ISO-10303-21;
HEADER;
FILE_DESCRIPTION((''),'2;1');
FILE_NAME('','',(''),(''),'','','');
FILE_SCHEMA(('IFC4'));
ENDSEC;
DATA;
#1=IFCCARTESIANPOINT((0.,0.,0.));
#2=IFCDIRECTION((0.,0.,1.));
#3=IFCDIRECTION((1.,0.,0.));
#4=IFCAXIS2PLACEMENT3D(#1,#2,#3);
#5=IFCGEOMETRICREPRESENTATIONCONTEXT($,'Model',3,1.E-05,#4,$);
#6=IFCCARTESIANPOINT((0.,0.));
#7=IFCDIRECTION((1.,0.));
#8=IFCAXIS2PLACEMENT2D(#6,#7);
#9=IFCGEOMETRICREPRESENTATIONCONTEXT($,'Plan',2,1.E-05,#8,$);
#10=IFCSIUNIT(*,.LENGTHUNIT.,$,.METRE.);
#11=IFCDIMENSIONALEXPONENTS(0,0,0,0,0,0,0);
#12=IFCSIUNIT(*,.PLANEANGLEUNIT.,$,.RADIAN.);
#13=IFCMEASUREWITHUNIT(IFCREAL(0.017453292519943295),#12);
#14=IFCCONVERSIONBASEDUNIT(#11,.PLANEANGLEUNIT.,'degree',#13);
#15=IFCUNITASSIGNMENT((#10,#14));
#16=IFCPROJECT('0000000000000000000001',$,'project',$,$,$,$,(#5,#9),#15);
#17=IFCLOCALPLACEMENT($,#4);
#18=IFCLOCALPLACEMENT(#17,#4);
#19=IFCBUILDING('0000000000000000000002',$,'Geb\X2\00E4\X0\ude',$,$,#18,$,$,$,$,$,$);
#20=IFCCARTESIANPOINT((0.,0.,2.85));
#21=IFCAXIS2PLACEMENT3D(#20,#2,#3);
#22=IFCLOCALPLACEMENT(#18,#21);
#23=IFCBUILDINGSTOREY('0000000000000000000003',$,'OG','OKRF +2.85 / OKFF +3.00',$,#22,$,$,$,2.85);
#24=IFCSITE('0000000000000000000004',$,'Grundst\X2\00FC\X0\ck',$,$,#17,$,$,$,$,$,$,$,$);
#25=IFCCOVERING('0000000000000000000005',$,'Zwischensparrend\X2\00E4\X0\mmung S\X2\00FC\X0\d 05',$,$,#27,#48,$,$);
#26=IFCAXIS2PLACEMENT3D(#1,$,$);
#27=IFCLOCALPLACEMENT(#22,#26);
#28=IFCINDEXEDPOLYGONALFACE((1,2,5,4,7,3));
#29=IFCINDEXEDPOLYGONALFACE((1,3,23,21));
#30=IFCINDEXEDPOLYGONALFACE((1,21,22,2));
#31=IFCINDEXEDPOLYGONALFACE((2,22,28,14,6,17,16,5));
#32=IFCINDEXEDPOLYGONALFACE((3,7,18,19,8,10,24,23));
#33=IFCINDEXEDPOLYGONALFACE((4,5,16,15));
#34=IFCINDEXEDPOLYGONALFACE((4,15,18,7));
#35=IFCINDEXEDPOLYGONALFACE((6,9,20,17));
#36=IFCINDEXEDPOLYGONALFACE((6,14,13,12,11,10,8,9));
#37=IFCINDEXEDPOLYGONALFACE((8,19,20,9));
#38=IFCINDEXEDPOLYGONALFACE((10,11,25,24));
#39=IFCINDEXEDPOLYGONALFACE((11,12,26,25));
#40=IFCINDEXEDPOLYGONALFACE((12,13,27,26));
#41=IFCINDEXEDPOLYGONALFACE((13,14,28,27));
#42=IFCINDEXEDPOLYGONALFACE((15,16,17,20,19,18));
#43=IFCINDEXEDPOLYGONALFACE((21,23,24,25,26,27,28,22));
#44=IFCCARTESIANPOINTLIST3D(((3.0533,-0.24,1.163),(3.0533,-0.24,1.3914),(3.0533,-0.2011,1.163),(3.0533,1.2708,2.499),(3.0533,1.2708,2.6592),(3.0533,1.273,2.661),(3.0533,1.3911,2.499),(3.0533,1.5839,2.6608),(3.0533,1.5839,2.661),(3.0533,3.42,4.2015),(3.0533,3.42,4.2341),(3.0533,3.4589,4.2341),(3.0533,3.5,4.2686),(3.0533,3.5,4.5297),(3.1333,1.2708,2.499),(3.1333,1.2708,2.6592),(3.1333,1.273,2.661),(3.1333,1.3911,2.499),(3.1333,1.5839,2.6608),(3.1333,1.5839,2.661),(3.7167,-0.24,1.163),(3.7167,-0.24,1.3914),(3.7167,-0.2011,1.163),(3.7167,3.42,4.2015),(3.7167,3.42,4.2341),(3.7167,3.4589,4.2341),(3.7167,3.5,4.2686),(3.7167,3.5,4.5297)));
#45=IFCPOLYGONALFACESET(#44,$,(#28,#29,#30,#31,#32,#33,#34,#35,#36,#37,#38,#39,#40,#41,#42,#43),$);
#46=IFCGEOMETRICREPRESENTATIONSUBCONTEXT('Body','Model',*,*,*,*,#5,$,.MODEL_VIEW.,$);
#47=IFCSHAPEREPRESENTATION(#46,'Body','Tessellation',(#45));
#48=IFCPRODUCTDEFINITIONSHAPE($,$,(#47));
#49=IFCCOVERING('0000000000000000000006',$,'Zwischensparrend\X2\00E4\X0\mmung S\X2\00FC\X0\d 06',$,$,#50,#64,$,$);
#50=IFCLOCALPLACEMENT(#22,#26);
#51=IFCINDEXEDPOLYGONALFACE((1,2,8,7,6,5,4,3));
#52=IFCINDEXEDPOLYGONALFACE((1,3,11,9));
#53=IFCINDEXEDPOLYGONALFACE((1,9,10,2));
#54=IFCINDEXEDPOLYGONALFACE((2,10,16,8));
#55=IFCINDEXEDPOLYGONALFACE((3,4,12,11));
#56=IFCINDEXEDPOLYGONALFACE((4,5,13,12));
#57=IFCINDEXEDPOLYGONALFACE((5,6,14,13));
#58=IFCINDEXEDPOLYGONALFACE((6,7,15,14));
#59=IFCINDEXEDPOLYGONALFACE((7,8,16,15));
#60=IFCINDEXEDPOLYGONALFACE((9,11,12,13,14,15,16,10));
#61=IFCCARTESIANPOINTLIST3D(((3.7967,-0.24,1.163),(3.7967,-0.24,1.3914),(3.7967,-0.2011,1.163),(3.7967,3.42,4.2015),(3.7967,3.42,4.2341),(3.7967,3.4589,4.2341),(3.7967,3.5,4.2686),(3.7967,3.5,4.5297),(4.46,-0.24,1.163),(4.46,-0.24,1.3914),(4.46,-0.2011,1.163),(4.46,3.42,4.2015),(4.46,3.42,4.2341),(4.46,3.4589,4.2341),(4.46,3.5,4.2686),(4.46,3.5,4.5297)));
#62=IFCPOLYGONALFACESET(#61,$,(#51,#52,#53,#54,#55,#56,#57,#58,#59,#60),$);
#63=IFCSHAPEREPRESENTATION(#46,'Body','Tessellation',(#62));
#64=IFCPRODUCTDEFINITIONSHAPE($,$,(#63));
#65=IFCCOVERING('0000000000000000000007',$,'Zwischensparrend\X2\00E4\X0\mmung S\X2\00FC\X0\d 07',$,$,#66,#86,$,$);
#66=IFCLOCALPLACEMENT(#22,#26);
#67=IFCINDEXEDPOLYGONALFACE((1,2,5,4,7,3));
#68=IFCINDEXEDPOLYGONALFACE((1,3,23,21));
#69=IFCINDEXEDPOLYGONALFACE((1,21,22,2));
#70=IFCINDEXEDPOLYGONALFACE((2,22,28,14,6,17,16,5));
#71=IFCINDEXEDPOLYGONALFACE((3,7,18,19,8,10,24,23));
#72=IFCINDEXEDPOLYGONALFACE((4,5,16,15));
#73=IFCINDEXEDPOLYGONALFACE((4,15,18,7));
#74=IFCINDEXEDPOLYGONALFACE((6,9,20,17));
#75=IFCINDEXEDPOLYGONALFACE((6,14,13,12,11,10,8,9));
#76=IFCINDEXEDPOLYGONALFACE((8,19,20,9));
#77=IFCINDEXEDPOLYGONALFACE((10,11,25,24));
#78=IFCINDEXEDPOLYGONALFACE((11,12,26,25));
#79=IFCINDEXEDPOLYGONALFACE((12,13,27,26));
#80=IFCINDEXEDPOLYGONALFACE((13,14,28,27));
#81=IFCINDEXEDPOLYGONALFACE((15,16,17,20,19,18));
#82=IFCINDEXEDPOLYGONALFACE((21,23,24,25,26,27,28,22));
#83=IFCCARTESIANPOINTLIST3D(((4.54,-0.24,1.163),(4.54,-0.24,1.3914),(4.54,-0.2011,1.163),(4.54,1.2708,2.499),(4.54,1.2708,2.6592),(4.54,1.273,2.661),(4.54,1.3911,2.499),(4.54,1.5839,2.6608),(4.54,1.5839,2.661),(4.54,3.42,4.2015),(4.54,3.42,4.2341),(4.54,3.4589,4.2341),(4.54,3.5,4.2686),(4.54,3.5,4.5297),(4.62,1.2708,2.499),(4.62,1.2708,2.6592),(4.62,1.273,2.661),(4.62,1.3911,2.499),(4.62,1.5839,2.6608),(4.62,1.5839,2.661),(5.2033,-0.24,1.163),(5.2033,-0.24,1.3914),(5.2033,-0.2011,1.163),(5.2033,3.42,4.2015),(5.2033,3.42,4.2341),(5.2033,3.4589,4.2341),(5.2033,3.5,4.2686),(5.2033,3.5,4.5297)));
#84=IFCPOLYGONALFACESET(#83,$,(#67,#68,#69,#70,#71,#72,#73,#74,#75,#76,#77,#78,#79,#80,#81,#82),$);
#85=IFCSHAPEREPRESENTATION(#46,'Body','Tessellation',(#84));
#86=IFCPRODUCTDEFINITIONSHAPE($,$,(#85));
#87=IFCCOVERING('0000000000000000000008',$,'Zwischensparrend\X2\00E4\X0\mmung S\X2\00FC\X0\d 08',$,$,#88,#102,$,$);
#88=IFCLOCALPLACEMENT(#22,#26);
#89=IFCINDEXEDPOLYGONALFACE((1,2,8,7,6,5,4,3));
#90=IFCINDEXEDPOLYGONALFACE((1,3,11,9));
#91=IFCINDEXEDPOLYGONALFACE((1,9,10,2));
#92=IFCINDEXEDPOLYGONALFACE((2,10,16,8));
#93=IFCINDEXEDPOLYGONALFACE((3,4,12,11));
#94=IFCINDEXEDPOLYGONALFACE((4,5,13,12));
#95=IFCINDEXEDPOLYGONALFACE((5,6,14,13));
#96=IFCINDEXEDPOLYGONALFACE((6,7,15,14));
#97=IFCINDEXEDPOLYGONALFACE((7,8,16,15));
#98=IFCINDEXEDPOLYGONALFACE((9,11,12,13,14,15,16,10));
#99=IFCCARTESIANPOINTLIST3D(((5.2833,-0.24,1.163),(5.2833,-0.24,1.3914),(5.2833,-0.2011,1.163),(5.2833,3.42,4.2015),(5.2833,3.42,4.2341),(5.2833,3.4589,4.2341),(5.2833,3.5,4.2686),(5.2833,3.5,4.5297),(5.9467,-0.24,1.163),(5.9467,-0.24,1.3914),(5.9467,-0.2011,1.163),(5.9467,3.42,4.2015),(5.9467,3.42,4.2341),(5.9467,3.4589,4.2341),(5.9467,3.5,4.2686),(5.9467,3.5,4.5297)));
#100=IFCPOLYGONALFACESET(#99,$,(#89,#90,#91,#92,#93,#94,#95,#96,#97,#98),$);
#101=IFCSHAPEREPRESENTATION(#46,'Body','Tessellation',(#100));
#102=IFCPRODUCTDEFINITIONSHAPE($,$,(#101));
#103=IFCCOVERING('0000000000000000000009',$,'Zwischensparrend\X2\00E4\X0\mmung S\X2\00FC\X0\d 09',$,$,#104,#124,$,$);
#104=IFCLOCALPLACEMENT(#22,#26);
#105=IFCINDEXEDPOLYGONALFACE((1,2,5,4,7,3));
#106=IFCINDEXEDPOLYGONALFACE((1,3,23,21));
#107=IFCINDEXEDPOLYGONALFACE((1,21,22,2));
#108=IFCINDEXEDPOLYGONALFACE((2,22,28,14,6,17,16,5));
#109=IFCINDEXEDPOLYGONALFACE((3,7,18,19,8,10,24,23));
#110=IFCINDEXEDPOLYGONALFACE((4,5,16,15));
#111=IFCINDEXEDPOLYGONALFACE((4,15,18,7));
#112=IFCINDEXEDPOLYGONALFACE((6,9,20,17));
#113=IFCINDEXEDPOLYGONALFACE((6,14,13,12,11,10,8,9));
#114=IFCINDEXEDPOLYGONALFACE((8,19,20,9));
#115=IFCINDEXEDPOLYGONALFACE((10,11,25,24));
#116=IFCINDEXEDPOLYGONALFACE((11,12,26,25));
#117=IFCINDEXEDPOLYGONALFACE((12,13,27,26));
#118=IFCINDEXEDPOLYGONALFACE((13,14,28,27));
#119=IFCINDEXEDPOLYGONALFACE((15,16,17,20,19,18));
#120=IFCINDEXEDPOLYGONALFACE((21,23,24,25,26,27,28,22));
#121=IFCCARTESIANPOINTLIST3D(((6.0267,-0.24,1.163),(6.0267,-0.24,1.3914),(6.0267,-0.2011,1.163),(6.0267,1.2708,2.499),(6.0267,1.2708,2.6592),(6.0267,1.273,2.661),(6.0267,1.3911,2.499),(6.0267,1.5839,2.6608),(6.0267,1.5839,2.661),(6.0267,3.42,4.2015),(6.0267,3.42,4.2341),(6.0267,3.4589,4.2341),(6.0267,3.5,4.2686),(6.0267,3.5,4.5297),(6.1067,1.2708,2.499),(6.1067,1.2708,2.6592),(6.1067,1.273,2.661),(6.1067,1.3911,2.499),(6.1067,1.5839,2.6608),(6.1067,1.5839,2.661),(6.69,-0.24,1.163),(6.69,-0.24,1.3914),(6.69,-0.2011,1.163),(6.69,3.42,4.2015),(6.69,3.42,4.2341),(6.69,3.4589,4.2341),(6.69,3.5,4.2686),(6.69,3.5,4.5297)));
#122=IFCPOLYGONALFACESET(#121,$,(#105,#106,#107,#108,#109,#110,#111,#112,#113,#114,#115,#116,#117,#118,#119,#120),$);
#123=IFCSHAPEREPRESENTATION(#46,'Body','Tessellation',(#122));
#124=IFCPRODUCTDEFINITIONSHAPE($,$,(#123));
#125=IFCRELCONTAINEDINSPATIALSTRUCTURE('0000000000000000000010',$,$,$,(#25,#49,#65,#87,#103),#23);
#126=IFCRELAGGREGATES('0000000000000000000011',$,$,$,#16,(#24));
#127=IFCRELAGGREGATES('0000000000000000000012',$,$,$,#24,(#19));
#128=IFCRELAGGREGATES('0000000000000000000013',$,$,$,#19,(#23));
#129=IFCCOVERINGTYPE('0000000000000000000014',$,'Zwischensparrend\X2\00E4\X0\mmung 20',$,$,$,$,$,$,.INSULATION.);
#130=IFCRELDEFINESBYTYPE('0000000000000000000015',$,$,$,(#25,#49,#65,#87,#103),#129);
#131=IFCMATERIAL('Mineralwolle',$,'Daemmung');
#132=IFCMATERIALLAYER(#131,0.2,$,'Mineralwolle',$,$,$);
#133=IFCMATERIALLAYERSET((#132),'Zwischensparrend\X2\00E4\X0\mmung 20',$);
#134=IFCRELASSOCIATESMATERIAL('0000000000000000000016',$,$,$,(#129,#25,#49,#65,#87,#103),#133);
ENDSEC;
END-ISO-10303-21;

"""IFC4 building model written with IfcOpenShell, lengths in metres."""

from ifc_helpers import new_model, entity, si_unit, converted_unit, frame, origin_with_axes, origin_2d_with_axis, place, context, subcontext, project, spatial, polyline, outline, extrude, material, layer, layer_set, layer_usage, type_object, element, save


model = new_model("IFC4")

# Units and contexts
model_context = context("Model", 3, precision=1e-05, world=origin_with_axes())
plan_context = context("Plan", 2, precision=1e-05, world=origin_2d_with_axis())
body_context = subcontext(model_context, "Body", "Model", "MODEL_VIEW")
ifc_project = project(units=[si_unit("LENGTHUNIT", "METRE"), converted_unit("PLANEANGLEUNIT", "degree", entity("IfcReal", 0.017453292519943295), si_unit("PLANEANGLEUNIT", "RADIAN"), dimensions=[0, 0, 0, 0, 0, 0, 0])], contexts=[model_context, plan_context])

# Site, building, storey
site_placement = place(None, origin_with_axes())
site = spatial("IfcSite", under=ifc_project, at=site_placement, Name="Grundstück")
building_placement = place(site_placement, origin_with_axes())
building = spatial("IfcBuilding", under=site, at=building_placement, Name="Gebäude")
storey_placement = place(building_placement, frame((0.0, 0.0, 2.85), z_axis=(0.0, 0.0, 1.0), x_axis=(1.0, 0.0, 0.0)))
storey = spatial("IfcBuildingStorey", under=building, at=storey_placement, Name="OG", Description="OKRF +2.85 / OKFF +3.00", Elevation=2.85)

# Covering, opening
ifc_material_1 = material(Name="Mineralwolle", Category="Daemmung")
ifc_layer = layer(ifc_material_1, 0.2, Name="Mineralwolle")
ifc_layer_set = layer_set([ifc_layer], Name="Zwischensparrendämmung 20")
ifc_layer_usage_1 = layer_usage(ifc_layer_set, "AXIS3", "POSITIVE", 0.0)
covering_type = type_object("IfcCoveringType", Name="Zwischensparrendämmung 20", PredefinedType="INSULATION", material=ifc_layer_set)
covering_1_placement = place(storey_placement, frame((3.0533, -0.24, 1.1304), z_axis=(0.0, -0.642788, 0.766044), x_axis=(1.0, 0.0, 0.0)))
covering_1 = element("IfcCovering", 1, at=covering_1_placement, inside=storey, type_object=covering_type, material=ifc_layer_usage_1, Name="Zwischensparrendämmung Süd 05", context=body_context, shape_type="SweptSolid", body=[
    extrude(outline(polyline([(0.021, 0.025), (0.0508, 0.0), (4.7778, 0.0), (4.7988, 0.025), (4.8286, 0.0), (4.8822, 0.0), (5.05, 0.2), (0.1678, 0.2), (0.021, 0.025)])), frame((0.0, 0.0, 0.0), z_axis=(1.0, 0.0, 0.0), x_axis=(0.0, 1.0, 0.0)), (0.0, 0.0, 1.0), 0.6633),
])
opening_1_placement = place(covering_1_placement, frame((-3.0533, -2.3747, -3.2034), z_axis=(0.0, 0.642788, 0.766044), x_axis=(1.0, 0.0, 0.0)))
element("IfcOpeningElement", 2, at=opening_1_placement, cuts=covering_1, PredefinedType="RECESS", context=body_context, shape_type="SweptSolid", body=[
    extrude(outline(polyline([(3.0533, 1.2708), (3.1333, 1.2708), (3.1333, 1.5839), (3.0533, 1.5839), (3.0533, 1.2708)])), frame((0.0, 0.0, 5.349), z_axis=(0.0, 0.0, 1.0), x_axis=(1.0, 0.0, 0.0)), (0.0, 0.0, 1.0), 0.162),
])

# Covering
ifc_layer_usage_2 = layer_usage(ifc_layer_set, "AXIS3", "POSITIVE", 0.0)
covering_2_placement = place(storey_placement, frame((3.7967, -0.24, 1.1304), z_axis=(0.0, -0.642788, 0.766044), x_axis=(1.0, 0.0, 0.0)))
element("IfcCovering", 3, at=covering_2_placement, inside=storey, type_object=covering_type, material=ifc_layer_usage_2, Name="Zwischensparrendämmung Süd 06", context=body_context, shape_type="SweptSolid", body=[
    extrude(outline(polyline([(0.021, 0.025), (0.0508, 0.0), (4.7778, 0.0), (4.7988, 0.025), (4.8286, 0.0), (4.8822, 0.0), (5.05, 0.2), (0.1678, 0.2), (0.021, 0.025)])), frame((0.0, 0.0, 0.0), z_axis=(1.0, 0.0, 0.0), x_axis=(0.0, 1.0, 0.0)), (0.0, 0.0, 1.0), 0.6633),
])

# Covering, opening
ifc_layer_usage_3 = layer_usage(ifc_layer_set, "AXIS3", "POSITIVE", 0.0)
covering_3_placement = place(storey_placement, frame((4.54, -0.24, 1.1304), z_axis=(0.0, -0.642788, 0.766044), x_axis=(1.0, 0.0, 0.0)))
covering_3 = element("IfcCovering", 4, at=covering_3_placement, inside=storey, type_object=covering_type, material=ifc_layer_usage_3, Name="Zwischensparrendämmung Süd 07", context=body_context, shape_type="SweptSolid", body=[
    extrude(outline(polyline([(0.021, 0.025), (0.0508, 0.0), (4.7778, 0.0), (4.7988, 0.025), (4.8286, 0.0), (4.8822, 0.0), (5.05, 0.2), (0.1678, 0.2), (0.021, 0.025)])), frame((0.0, 0.0, 0.0), z_axis=(1.0, 0.0, 0.0), x_axis=(0.0, 1.0, 0.0)), (0.0, 0.0, 1.0), 0.6633),
])
opening_2_placement = place(covering_3_placement, frame((-4.54, -2.3747, -3.2034), z_axis=(0.0, 0.642788, 0.766044), x_axis=(1.0, 0.0, 0.0)))
element("IfcOpeningElement", 5, at=opening_2_placement, cuts=covering_3, PredefinedType="RECESS", context=body_context, shape_type="SweptSolid", body=[
    extrude(outline(polyline([(4.54, 1.2708), (4.62, 1.2708), (4.62, 1.5839), (4.54, 1.5839), (4.54, 1.2708)])), frame((0.0, 0.0, 5.349), z_axis=(0.0, 0.0, 1.0), x_axis=(1.0, 0.0, 0.0)), (0.0, 0.0, 1.0), 0.162),
])

# Covering
ifc_layer_usage_4 = layer_usage(ifc_layer_set, "AXIS3", "POSITIVE", 0.0)
covering_4_placement = place(storey_placement, frame((5.2833, -0.24, 1.1304), z_axis=(0.0, -0.642788, 0.766044), x_axis=(1.0, 0.0, 0.0)))
element("IfcCovering", 6, at=covering_4_placement, inside=storey, type_object=covering_type, material=ifc_layer_usage_4, Name="Zwischensparrendämmung Süd 08", context=body_context, shape_type="SweptSolid", body=[
    extrude(outline(polyline([(0.021, 0.025), (0.0508, 0.0), (4.7778, 0.0), (4.7988, 0.025), (4.8286, 0.0), (4.8822, 0.0), (5.05, 0.2), (0.1678, 0.2), (0.021, 0.025)])), frame((0.0, 0.0, 0.0), z_axis=(1.0, 0.0, 0.0), x_axis=(0.0, 1.0, 0.0)), (0.0, 0.0, 1.0), 0.6633),
])

# Covering, opening
ifc_layer_usage_5 = layer_usage(ifc_layer_set, "AXIS3", "POSITIVE", 0.0)
covering_5_placement = place(storey_placement, frame((6.0267, -0.24, 1.1304), z_axis=(0.0, -0.642788, 0.766044), x_axis=(1.0, 0.0, 0.0)))
covering_5 = element("IfcCovering", 7, at=covering_5_placement, inside=storey, type_object=covering_type, material=ifc_layer_usage_5, Name="Zwischensparrendämmung Süd 09", context=body_context, shape_type="SweptSolid", body=[
    extrude(outline(polyline([(0.021, 0.025), (0.0508, 0.0), (4.7778, 0.0), (4.7988, 0.025), (4.8286, 0.0), (4.8822, 0.0), (5.05, 0.2), (0.1678, 0.2), (0.021, 0.025)])), frame((0.0, 0.0, 0.0), z_axis=(1.0, 0.0, 0.0), x_axis=(0.0, 1.0, 0.0)), (0.0, 0.0, 1.0), 0.6633),
])
opening_3_placement = place(covering_5_placement, frame((-6.0267, -2.3747, -3.2034), z_axis=(0.0, 0.642788, 0.766044), x_axis=(1.0, 0.0, 0.0)))
element("IfcOpeningElement", 8, at=opening_3_placement, cuts=covering_5, PredefinedType="RECESS", context=body_context, shape_type="SweptSolid", body=[
    extrude(outline(polyline([(6.0267, 1.2708), (6.1067, 1.2708), (6.1067, 1.5839), (6.0267, 1.5839), (6.0267, 1.2708)])), frame((0.0, 0.0, 5.349), z_axis=(0.0, 0.0, 1.0), x_axis=(1.0, 0.0, 0.0)), (0.0, 0.0, 1.0), 0.162),
])

save(model, "model.ifc")
